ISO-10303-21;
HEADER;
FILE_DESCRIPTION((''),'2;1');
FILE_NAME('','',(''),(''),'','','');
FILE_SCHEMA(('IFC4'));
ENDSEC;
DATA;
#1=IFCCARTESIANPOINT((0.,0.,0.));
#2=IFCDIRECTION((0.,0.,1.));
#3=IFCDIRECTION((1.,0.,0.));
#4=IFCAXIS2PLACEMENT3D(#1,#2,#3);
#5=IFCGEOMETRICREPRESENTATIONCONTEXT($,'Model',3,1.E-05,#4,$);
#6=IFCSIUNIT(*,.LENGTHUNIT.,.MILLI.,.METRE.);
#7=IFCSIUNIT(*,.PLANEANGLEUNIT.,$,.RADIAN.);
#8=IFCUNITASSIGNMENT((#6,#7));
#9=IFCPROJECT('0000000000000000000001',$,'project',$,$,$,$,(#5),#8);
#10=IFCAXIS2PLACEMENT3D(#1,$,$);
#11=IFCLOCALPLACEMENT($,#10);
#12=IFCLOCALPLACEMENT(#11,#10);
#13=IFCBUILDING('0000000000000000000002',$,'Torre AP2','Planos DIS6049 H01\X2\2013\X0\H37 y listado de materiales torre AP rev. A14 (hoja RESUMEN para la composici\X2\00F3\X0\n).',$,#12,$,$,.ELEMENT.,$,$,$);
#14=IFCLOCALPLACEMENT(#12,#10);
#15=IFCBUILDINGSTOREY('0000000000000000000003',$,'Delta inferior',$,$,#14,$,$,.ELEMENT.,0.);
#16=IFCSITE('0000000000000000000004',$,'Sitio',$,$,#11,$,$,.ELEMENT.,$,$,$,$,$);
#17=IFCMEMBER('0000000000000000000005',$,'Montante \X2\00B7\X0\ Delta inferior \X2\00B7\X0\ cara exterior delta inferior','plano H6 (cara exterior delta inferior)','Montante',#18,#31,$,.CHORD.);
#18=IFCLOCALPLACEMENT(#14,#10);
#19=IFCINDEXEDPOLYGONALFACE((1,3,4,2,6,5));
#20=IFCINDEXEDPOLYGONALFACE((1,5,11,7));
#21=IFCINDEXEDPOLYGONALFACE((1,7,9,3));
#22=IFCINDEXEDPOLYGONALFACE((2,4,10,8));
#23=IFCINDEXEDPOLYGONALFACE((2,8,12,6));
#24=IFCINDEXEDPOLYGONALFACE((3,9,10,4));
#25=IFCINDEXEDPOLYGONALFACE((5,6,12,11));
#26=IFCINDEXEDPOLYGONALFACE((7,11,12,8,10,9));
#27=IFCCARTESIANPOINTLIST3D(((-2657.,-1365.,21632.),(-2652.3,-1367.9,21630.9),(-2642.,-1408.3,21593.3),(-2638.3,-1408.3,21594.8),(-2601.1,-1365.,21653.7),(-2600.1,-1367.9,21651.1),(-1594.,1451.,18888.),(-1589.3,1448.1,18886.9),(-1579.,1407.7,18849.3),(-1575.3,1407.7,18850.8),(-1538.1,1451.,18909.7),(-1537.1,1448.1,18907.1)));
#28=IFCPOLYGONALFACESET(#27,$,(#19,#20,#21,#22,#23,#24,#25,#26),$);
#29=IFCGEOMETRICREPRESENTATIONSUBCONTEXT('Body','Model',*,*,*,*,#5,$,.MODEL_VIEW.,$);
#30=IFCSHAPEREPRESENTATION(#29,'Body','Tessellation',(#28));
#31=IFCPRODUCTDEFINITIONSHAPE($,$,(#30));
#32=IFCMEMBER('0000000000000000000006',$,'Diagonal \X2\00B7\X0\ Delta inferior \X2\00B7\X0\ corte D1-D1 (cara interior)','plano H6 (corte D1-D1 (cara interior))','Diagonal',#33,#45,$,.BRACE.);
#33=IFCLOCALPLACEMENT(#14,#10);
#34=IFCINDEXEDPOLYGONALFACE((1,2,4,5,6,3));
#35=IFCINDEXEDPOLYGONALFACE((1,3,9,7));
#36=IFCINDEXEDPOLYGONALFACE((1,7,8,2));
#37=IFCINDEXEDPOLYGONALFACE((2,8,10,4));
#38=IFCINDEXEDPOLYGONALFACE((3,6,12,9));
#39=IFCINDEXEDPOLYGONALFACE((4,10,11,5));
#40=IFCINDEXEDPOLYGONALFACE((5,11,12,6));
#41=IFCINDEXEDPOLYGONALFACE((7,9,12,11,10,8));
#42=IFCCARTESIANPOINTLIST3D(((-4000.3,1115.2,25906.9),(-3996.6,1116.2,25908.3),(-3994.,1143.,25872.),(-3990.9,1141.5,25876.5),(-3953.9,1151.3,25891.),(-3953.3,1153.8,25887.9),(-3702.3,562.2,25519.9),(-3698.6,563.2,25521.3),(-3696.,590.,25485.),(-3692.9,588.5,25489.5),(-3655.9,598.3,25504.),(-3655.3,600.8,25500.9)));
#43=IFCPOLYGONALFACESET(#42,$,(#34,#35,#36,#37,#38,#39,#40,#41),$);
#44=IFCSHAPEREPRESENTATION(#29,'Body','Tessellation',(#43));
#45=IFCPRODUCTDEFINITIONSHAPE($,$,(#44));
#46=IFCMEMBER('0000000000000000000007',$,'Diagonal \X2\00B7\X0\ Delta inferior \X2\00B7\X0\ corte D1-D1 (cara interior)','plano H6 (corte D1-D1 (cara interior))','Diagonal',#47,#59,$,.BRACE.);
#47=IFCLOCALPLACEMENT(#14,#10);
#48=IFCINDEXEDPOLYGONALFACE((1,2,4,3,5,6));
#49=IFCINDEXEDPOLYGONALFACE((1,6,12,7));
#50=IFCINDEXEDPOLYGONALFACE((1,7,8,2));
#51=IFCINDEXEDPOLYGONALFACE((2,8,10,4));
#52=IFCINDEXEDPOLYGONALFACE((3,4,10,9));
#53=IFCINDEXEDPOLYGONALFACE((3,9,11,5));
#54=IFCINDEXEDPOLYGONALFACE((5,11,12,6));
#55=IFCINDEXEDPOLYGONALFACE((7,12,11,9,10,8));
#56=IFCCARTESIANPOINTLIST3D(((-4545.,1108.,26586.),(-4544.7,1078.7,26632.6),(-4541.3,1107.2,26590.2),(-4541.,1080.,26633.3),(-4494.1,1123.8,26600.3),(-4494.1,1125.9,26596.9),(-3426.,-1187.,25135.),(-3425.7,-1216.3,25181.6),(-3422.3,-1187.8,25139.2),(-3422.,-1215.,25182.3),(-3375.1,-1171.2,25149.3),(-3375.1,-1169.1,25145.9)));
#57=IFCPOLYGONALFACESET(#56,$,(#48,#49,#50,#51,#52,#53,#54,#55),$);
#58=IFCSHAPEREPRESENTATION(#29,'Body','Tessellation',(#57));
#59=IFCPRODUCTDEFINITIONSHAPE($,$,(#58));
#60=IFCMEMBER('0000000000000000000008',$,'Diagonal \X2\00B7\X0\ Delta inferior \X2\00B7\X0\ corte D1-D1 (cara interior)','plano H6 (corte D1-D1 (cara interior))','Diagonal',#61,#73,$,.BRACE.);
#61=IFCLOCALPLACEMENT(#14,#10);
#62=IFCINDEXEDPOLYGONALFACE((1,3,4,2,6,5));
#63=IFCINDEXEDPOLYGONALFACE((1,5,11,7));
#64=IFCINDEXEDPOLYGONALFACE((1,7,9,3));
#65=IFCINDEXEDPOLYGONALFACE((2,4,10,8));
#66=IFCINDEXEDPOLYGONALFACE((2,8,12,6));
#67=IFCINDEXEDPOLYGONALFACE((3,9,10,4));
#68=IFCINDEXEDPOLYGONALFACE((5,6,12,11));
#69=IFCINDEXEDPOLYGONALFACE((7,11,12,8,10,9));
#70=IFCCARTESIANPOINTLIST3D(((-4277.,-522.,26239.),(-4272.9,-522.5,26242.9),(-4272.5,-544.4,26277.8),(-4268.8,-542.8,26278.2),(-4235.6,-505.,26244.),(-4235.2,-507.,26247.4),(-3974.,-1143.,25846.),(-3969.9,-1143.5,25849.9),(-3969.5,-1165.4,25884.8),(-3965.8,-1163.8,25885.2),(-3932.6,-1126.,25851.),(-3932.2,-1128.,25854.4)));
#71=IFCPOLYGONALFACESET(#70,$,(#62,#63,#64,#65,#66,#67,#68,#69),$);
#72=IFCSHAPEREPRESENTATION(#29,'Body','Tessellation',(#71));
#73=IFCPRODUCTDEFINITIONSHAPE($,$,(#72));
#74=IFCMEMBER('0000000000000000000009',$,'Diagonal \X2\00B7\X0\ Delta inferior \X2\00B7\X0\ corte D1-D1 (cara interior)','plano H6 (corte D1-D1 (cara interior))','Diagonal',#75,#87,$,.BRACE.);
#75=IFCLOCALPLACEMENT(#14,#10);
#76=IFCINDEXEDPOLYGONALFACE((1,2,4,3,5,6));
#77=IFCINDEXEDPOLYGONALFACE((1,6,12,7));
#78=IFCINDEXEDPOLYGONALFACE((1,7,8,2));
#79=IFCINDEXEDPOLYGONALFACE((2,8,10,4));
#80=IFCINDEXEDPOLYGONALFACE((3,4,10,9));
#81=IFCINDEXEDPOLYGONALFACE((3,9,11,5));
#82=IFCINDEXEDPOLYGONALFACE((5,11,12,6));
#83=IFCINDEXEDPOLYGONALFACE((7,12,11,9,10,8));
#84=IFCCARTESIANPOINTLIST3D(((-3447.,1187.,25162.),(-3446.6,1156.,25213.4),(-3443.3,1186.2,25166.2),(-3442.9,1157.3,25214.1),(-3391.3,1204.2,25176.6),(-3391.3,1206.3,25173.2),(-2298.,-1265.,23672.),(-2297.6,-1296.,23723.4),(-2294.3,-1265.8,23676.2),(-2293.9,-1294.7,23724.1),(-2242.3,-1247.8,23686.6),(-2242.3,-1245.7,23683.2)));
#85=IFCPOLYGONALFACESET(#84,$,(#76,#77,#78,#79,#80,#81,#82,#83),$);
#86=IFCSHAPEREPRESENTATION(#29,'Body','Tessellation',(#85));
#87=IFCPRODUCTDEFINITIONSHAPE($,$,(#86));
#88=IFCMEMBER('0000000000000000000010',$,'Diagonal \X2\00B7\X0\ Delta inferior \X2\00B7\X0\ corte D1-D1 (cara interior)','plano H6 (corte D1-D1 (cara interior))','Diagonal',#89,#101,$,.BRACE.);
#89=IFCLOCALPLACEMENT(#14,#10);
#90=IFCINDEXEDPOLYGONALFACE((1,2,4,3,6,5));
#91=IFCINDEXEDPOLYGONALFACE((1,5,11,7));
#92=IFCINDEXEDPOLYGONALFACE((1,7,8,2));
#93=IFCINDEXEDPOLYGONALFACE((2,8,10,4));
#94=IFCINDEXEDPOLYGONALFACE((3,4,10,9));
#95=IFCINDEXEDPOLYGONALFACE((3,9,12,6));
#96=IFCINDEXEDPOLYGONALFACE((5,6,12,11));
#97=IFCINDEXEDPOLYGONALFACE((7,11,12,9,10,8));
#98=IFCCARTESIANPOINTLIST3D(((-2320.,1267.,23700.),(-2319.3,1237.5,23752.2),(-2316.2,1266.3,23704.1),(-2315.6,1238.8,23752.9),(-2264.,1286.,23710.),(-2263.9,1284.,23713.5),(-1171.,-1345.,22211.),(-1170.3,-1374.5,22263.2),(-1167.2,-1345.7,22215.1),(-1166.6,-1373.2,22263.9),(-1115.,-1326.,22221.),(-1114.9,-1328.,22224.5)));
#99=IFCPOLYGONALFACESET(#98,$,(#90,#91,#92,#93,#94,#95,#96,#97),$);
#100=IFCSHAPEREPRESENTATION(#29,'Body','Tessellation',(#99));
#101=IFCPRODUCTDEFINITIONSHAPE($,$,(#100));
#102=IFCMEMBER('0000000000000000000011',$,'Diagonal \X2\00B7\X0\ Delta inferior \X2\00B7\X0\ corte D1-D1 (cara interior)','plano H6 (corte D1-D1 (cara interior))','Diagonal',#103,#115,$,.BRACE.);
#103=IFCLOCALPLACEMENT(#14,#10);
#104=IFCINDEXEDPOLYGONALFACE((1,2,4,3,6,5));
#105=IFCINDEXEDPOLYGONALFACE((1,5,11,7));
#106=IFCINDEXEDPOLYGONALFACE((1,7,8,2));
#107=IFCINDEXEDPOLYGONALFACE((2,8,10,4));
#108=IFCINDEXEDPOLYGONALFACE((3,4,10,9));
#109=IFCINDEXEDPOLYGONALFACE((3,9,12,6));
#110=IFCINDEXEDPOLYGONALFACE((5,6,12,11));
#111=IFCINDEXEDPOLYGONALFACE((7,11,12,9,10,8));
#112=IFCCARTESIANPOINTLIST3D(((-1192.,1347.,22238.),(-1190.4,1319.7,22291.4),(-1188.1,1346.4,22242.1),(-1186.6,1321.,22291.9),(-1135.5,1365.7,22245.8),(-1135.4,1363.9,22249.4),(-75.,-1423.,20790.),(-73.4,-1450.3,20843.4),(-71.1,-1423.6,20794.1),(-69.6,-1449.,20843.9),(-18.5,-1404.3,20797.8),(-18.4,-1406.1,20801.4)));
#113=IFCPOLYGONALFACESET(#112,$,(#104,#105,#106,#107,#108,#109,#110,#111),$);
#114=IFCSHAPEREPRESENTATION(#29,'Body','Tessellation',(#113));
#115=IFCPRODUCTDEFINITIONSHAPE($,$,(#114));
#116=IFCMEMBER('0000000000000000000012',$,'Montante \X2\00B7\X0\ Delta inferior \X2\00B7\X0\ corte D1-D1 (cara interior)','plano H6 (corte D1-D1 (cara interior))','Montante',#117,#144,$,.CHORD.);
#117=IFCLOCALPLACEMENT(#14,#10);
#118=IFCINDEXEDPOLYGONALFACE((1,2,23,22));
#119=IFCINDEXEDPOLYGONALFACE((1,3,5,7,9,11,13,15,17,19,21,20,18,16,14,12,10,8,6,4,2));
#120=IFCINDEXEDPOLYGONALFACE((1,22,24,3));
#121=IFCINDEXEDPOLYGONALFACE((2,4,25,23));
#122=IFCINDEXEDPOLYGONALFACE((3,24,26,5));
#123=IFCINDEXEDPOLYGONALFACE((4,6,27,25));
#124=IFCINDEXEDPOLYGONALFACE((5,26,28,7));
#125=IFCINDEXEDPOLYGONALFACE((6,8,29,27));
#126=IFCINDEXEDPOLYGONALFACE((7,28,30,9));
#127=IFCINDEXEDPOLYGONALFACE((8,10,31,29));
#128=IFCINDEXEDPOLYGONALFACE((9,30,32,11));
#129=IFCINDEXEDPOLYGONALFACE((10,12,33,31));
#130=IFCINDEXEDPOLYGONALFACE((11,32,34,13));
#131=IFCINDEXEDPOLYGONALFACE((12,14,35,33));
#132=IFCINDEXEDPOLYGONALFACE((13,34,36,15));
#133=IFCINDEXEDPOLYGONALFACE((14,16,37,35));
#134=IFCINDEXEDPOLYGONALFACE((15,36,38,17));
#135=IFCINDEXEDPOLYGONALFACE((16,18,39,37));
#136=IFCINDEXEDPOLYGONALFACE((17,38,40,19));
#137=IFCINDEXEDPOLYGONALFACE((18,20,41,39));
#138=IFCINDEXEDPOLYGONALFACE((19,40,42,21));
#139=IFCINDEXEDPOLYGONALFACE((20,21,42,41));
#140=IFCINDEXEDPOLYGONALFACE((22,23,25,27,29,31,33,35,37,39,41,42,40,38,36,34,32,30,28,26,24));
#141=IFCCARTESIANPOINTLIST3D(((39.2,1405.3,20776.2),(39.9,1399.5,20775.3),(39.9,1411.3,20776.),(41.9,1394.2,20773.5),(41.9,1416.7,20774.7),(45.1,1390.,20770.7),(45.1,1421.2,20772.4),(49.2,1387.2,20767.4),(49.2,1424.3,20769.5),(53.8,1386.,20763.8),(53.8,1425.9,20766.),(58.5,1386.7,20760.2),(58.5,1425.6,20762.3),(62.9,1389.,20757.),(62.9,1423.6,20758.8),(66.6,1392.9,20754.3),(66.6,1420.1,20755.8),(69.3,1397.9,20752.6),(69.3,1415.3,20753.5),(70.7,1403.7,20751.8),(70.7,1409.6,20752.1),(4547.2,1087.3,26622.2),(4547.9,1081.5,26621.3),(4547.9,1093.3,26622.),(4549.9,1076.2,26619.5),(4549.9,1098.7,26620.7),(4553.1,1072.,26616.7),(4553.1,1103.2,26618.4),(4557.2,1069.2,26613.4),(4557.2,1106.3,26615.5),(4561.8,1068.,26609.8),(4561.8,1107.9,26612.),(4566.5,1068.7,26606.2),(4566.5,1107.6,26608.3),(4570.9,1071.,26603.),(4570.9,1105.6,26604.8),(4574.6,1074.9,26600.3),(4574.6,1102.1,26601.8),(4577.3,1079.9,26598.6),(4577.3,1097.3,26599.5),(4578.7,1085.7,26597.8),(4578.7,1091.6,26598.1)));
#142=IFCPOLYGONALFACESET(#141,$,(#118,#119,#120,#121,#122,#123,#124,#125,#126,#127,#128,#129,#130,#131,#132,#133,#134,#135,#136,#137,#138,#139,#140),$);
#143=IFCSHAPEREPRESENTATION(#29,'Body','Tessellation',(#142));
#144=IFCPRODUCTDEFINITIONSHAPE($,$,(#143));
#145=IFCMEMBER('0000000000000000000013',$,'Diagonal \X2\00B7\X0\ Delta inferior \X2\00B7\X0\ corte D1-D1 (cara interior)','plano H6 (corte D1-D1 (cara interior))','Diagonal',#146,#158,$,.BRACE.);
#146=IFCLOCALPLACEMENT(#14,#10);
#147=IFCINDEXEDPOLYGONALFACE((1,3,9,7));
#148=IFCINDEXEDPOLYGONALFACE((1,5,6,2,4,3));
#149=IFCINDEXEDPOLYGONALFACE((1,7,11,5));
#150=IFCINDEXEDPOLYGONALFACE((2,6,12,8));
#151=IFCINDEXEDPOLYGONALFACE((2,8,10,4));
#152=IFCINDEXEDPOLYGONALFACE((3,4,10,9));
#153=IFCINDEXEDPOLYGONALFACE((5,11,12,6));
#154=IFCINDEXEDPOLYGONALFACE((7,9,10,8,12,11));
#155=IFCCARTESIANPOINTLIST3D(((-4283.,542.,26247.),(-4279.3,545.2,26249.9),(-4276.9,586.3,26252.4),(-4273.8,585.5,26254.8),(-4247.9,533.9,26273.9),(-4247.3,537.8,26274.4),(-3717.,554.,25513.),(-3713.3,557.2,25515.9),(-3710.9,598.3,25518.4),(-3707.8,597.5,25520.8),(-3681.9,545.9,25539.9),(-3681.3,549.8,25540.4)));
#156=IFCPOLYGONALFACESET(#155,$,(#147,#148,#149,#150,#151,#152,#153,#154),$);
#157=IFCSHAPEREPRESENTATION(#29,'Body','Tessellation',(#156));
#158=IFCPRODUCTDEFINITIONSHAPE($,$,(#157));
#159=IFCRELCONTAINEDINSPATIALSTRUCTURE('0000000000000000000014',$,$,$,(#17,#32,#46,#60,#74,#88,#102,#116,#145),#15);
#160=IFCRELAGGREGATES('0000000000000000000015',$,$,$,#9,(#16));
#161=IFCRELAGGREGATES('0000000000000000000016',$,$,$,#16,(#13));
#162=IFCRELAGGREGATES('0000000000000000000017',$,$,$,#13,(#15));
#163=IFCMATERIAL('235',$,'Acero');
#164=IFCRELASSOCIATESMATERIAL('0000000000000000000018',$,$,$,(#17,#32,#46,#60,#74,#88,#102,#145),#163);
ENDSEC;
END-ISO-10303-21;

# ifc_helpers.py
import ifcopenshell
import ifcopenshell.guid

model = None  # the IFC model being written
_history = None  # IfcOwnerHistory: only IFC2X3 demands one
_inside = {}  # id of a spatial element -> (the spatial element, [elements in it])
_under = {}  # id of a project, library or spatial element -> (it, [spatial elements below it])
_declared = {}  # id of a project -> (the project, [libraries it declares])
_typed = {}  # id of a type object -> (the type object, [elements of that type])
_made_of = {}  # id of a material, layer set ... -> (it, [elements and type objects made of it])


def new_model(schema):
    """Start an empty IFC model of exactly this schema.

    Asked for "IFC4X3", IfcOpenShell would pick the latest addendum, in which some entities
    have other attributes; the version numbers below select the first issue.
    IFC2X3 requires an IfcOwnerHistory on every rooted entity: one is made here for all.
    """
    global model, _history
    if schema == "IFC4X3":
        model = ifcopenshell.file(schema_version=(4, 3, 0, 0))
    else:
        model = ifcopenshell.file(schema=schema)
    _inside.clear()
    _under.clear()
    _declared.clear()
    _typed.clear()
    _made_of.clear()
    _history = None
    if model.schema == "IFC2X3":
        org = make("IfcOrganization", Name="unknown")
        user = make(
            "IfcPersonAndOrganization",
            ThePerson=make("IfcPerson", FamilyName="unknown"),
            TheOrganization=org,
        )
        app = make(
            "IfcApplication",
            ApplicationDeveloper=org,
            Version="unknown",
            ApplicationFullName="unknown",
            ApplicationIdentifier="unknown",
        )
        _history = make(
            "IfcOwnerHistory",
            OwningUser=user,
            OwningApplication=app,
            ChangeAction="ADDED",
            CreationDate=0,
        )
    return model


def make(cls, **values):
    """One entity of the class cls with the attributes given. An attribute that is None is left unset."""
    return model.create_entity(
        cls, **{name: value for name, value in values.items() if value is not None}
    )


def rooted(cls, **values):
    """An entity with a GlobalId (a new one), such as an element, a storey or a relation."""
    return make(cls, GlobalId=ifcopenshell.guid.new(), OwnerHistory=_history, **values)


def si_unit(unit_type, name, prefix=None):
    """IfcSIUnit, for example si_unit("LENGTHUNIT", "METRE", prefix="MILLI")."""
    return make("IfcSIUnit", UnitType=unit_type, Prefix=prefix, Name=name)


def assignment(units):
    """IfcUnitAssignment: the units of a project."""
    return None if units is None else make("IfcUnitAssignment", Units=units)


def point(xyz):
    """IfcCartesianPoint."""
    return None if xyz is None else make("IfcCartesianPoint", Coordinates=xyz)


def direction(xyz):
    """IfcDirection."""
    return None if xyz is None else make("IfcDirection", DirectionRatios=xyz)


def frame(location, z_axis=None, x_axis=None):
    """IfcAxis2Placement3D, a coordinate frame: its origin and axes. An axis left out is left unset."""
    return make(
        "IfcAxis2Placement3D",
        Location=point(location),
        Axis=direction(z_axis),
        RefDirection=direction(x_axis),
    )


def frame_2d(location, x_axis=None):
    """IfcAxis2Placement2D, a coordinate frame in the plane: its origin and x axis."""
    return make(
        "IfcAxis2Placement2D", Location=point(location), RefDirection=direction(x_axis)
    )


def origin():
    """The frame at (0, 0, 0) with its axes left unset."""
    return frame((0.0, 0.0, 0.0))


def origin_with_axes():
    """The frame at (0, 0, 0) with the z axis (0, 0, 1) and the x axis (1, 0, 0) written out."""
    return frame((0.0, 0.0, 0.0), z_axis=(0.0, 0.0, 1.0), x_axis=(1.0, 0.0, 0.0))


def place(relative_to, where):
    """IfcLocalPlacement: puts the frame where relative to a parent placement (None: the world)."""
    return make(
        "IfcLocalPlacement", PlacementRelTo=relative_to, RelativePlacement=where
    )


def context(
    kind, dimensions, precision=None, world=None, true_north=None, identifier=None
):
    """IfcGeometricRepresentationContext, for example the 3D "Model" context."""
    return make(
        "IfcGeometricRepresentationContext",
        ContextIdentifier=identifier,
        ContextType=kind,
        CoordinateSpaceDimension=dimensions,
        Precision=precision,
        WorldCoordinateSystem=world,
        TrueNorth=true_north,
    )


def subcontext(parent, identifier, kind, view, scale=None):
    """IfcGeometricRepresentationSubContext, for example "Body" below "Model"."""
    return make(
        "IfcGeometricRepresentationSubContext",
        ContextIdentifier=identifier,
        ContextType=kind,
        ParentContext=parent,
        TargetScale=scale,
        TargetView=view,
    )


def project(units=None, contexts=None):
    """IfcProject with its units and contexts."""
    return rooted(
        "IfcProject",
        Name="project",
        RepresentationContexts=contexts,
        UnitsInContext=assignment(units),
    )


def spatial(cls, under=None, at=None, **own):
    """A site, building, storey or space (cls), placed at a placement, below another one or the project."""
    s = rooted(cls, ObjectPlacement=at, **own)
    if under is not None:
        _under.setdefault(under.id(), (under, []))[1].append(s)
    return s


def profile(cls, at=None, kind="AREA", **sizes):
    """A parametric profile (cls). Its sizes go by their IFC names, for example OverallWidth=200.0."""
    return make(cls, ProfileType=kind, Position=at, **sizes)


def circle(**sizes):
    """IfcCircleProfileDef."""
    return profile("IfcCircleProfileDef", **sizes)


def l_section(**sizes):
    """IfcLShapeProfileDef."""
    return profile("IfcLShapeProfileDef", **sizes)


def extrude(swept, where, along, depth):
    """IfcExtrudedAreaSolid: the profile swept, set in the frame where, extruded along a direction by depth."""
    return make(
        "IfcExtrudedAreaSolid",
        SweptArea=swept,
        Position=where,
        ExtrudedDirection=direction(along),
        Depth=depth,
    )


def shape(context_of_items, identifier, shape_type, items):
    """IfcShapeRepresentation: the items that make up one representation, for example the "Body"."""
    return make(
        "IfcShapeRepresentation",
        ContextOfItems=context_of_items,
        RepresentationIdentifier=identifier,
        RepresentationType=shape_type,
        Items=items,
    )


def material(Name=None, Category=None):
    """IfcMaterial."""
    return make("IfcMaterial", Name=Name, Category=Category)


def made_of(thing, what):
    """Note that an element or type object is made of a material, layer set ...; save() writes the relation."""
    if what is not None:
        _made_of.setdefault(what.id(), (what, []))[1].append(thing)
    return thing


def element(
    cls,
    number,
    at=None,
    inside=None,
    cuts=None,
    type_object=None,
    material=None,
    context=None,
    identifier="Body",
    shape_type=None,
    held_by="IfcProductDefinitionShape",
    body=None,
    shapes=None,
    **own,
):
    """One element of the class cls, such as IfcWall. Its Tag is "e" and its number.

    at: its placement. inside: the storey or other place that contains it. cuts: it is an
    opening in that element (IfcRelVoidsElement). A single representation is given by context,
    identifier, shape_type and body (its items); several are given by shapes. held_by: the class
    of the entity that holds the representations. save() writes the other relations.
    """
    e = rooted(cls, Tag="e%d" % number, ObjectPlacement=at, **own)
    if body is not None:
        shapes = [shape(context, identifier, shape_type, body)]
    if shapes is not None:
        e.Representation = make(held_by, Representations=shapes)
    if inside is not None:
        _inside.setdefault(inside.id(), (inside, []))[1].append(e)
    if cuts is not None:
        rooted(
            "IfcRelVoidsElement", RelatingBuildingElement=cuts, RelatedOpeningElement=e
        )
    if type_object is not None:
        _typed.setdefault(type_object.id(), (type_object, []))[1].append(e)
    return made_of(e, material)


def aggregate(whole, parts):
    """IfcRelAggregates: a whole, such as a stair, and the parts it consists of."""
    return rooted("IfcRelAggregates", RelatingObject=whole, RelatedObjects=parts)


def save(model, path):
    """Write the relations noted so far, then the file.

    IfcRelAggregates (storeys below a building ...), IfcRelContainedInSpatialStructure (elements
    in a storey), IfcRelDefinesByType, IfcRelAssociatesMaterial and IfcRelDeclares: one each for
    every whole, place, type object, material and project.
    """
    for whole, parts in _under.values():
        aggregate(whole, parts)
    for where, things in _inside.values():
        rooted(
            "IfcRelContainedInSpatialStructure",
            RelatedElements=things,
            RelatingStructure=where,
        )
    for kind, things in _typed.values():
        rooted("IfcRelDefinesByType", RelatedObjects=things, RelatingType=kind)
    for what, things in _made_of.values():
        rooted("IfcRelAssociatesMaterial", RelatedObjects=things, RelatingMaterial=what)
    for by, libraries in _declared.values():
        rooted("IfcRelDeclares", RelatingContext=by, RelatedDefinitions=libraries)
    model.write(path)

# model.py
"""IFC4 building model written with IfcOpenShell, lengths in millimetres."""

from ifc_helpers import new_model, si_unit, frame, frame_2d, origin, origin_with_axes, place, context, subcontext, project, spatial, circle, l_section, extrude, material, element, save


model = new_model("IFC4")

# Units and contexts
model_context = context("Model", 3, precision=1e-05, world=origin_with_axes())
body_context = subcontext(model_context, "Body", "Model", "MODEL_VIEW")
ifc_project = project(units=[si_unit("LENGTHUNIT", "METRE", prefix="MILLI"), si_unit("PLANEANGLEUNIT", "RADIAN")], contexts=[model_context])

# Site, building, storey
site_placement = place(None, origin())
site = spatial("IfcSite", under=ifc_project, at=site_placement, Name="Sitio", CompositionType="ELEMENT")
building_placement = place(site_placement, origin())
building = spatial("IfcBuilding", under=site, at=building_placement, Name="Torre AP2", Description="Planos DIS6049 H01–H37 y listado de materiales torre AP rev. A14 (hoja RESUMEN para la composición).", CompositionType="ELEMENT")
storey_placement = place(building_placement, origin())
storey = spatial("IfcBuildingStorey", under=building, at=storey_placement, Name="Delta inferior", CompositionType="ELEMENT", Elevation=0.0)

# Members
ifc_material_1 = material(Name="235", Category="Acero")
member_1_placement = place(storey_placement, frame((-1594.0, 1451.0, 18888.0), z_axis=(-0.260987, -0.691382, 0.673704), x_axis=(0.249749, -0.72249, -0.644697)))
element("IfcMember", 1, at=member_1_placement, inside=storey, material=ifc_material_1, Name="Montante · Delta inferior · cara exterior delta inferior", Description="plano H6 (cara exterior delta inferior)", ObjectType="Montante", PredefinedType="CHORD", context=body_context, shape_type="SweptSolid", body=[
    extrude(l_section(Depth=60.0, Width=60.0, Thickness=4.0, at=frame_2d((30.0, 30.0))), None, (0.0, 0.0, 1.0), 4073.0),
])
member_2_placement = place(storey_placement, frame((-3994.0, 1143.0, 25872.0), z_axis=(0.403891, -0.749503, -0.524516), x_axis=(0.904178, 0.239916, 0.353414)))
element("IfcMember", 2, at=member_2_placement, inside=storey, material=ifc_material_1, Name="Diagonal · Delta inferior · corte D1-D1 (cara interior)", Description="plano H6 (corte D1-D1 (cara interior))", ObjectType="Diagonal", PredefinedType="BRACE", context=body_context, shape_type="SweptSolid", body=[
    extrude(l_section(Depth=45.0, Width=45.0, Thickness=4.0, at=frame_2d((22.5, 22.5))), None, (0.0, 0.0, 1.0), 737.8),
])
member_3_placement = place(storey_placement, frame((-4545.0, 1108.0, 26586.0), z_axis=(0.381032, -0.781472, -0.494081), x_axis=(0.924547, 0.325107, 0.198793)))
element("IfcMember", 3, at=member_3_placement, inside=storey, material=ifc_material_1, Name="Diagonal · Delta inferior · corte D1-D1 (cara interior)", Description="plano H6 (corte D1-D1 (cara interior))", ObjectType="Diagonal", PredefinedType="BRACE", context=body_context, shape_type="SweptSolid", body=[
    extrude(l_section(Depth=55.0, Width=55.0, Thickness=4.0, at=frame_2d((27.5, 27.5))), None, (0.0, 0.0, 1.0), 2936.8),
])
member_4_placement = place(storey_placement, frame((-4277.0, -522.0, 26239.0), z_axis=(0.38117, -0.78121, -0.494389), x_axis=(0.919056, 0.378167, 0.111023)))
element("IfcMember", 4, at=member_4_placement, inside=storey, material=ifc_material_1, Name="Diagonal · Delta inferior · corte D1-D1 (cara interior)", Description="plano H6 (corte D1-D1 (cara interior))", ObjectType="Diagonal", PredefinedType="BRACE", context=body_context, shape_type="SweptSolid", body=[
    extrude(l_section(Depth=45.0, Width=45.0, Thickness=4.0, at=frame_2d((22.5, 22.5))), None, (0.0, 0.0, 1.0), 794.9),
])
member_5_placement = place(storey_placement, frame((-3447.0, 1187.0, 25162.0), z_axis=(0.371757, -0.79334, -0.482087), x_axis=(0.928304, 0.321616, 0.18659)))
element("IfcMember", 5, at=member_5_placement, inside=storey, material=ifc_material_1, Name="Diagonal · Delta inferior · corte D1-D1 (cara interior)", Description="plano H6 (corte D1-D1 (cara interior))", ObjectType="Diagonal", PredefinedType="BRACE", context=body_context, shape_type="SweptSolid", body=[
    extrude(l_section(Depth=60.0, Width=60.0, Thickness=4.0, at=frame_2d((30.0, 30.0))), None, (0.0, 0.0, 1.0), 3090.7),
])
member_6_placement = place(storey_placement, frame((-2320.0, 1267.0, 23700.0), z_axis=(0.356979, -0.811514, -0.462613), x_axis=(0.934048, 0.315929, 0.166565)))
element("IfcMember", 6, at=member_6_placement, inside=storey, material=ifc_material_1, Name="Diagonal · Delta inferior · corte D1-D1 (cara interior)", Description="plano H6 (corte D1-D1 (cara interior))", ObjectType="Diagonal", PredefinedType="BRACE", context=body_context, shape_type="SweptSolid", body=[
    extrude(l_section(Depth=60.0, Width=60.0, Thickness=4.0, at=frame_2d((30.0, 30.0))), None, (0.0, 0.0, 1.0), 3218.7),
])
member_7_placement = place(storey_placement, frame((-1192.0, 1347.0, 22238.0), z_axis=(0.336524, -0.834531, -0.436246), x_axis=(0.94128, 0.311519, 0.130181)))
element("IfcMember", 7, at=member_7_placement, inside=storey, material=ifc_material_1, Name="Diagonal · Delta inferior · corte D1-D1 (cara interior)", Description="plano H6 (corte D1-D1 (cara interior))", ObjectType="Diagonal", PredefinedType="BRACE", context=body_context, shape_type="SweptSolid", body=[
    extrude(l_section(Depth=60.0, Width=60.0, Thickness=4.0, at=frame_2d((30.0, 30.0))), None, (0.0, 0.0, 1.0), 3319.2),
])
for number, where, z_axis, x_axis, name in (
    (8, (55.0, 1406.0, 20764.0), (0.610087, -0.043036, 0.791165), (-0.792334, -0.033137, 0.609187), "Montante · Delta inferior · corte D1-D1 (cara interior)"),
):
    element("IfcMember", number, at=place(storey_placement, frame(where, z_axis=z_axis, x_axis=x_axis)), inside=storey, Name=name, Description="plano H6 (corte D1-D1 (cara interior))", ObjectType="Montante", PredefinedType="CHORD", context=body_context, shape_type="SweptSolid", body=[
        extrude(circle(Radius=20.0), None, (0.0, 0.0, 1.0), 7389.1),
    ])
member_8_placement = place(storey_placement, frame((-3717.0, 554.0, 25513.0), z_axis=(-0.610598, -0.012946, 0.791835), x_axis=(0.780393, -0.179966, 0.598832)))
element("IfcMember", 9, at=member_8_placement, inside=storey, material=ifc_material_1, Name="Diagonal · Delta inferior · corte D1-D1 (cara interior)", Description="plano H6 (corte D1-D1 (cara interior))", ObjectType="Diagonal", PredefinedType="BRACE", context=body_context, shape_type="SweptSolid", body=[
    extrude(l_section(Depth=45.0, Width=45.0, Thickness=4.0, at=frame_2d((22.5, 22.5))), None, (0.0, 0.0, 1.0), 927.0),
])

save(model, "model.ifc")
